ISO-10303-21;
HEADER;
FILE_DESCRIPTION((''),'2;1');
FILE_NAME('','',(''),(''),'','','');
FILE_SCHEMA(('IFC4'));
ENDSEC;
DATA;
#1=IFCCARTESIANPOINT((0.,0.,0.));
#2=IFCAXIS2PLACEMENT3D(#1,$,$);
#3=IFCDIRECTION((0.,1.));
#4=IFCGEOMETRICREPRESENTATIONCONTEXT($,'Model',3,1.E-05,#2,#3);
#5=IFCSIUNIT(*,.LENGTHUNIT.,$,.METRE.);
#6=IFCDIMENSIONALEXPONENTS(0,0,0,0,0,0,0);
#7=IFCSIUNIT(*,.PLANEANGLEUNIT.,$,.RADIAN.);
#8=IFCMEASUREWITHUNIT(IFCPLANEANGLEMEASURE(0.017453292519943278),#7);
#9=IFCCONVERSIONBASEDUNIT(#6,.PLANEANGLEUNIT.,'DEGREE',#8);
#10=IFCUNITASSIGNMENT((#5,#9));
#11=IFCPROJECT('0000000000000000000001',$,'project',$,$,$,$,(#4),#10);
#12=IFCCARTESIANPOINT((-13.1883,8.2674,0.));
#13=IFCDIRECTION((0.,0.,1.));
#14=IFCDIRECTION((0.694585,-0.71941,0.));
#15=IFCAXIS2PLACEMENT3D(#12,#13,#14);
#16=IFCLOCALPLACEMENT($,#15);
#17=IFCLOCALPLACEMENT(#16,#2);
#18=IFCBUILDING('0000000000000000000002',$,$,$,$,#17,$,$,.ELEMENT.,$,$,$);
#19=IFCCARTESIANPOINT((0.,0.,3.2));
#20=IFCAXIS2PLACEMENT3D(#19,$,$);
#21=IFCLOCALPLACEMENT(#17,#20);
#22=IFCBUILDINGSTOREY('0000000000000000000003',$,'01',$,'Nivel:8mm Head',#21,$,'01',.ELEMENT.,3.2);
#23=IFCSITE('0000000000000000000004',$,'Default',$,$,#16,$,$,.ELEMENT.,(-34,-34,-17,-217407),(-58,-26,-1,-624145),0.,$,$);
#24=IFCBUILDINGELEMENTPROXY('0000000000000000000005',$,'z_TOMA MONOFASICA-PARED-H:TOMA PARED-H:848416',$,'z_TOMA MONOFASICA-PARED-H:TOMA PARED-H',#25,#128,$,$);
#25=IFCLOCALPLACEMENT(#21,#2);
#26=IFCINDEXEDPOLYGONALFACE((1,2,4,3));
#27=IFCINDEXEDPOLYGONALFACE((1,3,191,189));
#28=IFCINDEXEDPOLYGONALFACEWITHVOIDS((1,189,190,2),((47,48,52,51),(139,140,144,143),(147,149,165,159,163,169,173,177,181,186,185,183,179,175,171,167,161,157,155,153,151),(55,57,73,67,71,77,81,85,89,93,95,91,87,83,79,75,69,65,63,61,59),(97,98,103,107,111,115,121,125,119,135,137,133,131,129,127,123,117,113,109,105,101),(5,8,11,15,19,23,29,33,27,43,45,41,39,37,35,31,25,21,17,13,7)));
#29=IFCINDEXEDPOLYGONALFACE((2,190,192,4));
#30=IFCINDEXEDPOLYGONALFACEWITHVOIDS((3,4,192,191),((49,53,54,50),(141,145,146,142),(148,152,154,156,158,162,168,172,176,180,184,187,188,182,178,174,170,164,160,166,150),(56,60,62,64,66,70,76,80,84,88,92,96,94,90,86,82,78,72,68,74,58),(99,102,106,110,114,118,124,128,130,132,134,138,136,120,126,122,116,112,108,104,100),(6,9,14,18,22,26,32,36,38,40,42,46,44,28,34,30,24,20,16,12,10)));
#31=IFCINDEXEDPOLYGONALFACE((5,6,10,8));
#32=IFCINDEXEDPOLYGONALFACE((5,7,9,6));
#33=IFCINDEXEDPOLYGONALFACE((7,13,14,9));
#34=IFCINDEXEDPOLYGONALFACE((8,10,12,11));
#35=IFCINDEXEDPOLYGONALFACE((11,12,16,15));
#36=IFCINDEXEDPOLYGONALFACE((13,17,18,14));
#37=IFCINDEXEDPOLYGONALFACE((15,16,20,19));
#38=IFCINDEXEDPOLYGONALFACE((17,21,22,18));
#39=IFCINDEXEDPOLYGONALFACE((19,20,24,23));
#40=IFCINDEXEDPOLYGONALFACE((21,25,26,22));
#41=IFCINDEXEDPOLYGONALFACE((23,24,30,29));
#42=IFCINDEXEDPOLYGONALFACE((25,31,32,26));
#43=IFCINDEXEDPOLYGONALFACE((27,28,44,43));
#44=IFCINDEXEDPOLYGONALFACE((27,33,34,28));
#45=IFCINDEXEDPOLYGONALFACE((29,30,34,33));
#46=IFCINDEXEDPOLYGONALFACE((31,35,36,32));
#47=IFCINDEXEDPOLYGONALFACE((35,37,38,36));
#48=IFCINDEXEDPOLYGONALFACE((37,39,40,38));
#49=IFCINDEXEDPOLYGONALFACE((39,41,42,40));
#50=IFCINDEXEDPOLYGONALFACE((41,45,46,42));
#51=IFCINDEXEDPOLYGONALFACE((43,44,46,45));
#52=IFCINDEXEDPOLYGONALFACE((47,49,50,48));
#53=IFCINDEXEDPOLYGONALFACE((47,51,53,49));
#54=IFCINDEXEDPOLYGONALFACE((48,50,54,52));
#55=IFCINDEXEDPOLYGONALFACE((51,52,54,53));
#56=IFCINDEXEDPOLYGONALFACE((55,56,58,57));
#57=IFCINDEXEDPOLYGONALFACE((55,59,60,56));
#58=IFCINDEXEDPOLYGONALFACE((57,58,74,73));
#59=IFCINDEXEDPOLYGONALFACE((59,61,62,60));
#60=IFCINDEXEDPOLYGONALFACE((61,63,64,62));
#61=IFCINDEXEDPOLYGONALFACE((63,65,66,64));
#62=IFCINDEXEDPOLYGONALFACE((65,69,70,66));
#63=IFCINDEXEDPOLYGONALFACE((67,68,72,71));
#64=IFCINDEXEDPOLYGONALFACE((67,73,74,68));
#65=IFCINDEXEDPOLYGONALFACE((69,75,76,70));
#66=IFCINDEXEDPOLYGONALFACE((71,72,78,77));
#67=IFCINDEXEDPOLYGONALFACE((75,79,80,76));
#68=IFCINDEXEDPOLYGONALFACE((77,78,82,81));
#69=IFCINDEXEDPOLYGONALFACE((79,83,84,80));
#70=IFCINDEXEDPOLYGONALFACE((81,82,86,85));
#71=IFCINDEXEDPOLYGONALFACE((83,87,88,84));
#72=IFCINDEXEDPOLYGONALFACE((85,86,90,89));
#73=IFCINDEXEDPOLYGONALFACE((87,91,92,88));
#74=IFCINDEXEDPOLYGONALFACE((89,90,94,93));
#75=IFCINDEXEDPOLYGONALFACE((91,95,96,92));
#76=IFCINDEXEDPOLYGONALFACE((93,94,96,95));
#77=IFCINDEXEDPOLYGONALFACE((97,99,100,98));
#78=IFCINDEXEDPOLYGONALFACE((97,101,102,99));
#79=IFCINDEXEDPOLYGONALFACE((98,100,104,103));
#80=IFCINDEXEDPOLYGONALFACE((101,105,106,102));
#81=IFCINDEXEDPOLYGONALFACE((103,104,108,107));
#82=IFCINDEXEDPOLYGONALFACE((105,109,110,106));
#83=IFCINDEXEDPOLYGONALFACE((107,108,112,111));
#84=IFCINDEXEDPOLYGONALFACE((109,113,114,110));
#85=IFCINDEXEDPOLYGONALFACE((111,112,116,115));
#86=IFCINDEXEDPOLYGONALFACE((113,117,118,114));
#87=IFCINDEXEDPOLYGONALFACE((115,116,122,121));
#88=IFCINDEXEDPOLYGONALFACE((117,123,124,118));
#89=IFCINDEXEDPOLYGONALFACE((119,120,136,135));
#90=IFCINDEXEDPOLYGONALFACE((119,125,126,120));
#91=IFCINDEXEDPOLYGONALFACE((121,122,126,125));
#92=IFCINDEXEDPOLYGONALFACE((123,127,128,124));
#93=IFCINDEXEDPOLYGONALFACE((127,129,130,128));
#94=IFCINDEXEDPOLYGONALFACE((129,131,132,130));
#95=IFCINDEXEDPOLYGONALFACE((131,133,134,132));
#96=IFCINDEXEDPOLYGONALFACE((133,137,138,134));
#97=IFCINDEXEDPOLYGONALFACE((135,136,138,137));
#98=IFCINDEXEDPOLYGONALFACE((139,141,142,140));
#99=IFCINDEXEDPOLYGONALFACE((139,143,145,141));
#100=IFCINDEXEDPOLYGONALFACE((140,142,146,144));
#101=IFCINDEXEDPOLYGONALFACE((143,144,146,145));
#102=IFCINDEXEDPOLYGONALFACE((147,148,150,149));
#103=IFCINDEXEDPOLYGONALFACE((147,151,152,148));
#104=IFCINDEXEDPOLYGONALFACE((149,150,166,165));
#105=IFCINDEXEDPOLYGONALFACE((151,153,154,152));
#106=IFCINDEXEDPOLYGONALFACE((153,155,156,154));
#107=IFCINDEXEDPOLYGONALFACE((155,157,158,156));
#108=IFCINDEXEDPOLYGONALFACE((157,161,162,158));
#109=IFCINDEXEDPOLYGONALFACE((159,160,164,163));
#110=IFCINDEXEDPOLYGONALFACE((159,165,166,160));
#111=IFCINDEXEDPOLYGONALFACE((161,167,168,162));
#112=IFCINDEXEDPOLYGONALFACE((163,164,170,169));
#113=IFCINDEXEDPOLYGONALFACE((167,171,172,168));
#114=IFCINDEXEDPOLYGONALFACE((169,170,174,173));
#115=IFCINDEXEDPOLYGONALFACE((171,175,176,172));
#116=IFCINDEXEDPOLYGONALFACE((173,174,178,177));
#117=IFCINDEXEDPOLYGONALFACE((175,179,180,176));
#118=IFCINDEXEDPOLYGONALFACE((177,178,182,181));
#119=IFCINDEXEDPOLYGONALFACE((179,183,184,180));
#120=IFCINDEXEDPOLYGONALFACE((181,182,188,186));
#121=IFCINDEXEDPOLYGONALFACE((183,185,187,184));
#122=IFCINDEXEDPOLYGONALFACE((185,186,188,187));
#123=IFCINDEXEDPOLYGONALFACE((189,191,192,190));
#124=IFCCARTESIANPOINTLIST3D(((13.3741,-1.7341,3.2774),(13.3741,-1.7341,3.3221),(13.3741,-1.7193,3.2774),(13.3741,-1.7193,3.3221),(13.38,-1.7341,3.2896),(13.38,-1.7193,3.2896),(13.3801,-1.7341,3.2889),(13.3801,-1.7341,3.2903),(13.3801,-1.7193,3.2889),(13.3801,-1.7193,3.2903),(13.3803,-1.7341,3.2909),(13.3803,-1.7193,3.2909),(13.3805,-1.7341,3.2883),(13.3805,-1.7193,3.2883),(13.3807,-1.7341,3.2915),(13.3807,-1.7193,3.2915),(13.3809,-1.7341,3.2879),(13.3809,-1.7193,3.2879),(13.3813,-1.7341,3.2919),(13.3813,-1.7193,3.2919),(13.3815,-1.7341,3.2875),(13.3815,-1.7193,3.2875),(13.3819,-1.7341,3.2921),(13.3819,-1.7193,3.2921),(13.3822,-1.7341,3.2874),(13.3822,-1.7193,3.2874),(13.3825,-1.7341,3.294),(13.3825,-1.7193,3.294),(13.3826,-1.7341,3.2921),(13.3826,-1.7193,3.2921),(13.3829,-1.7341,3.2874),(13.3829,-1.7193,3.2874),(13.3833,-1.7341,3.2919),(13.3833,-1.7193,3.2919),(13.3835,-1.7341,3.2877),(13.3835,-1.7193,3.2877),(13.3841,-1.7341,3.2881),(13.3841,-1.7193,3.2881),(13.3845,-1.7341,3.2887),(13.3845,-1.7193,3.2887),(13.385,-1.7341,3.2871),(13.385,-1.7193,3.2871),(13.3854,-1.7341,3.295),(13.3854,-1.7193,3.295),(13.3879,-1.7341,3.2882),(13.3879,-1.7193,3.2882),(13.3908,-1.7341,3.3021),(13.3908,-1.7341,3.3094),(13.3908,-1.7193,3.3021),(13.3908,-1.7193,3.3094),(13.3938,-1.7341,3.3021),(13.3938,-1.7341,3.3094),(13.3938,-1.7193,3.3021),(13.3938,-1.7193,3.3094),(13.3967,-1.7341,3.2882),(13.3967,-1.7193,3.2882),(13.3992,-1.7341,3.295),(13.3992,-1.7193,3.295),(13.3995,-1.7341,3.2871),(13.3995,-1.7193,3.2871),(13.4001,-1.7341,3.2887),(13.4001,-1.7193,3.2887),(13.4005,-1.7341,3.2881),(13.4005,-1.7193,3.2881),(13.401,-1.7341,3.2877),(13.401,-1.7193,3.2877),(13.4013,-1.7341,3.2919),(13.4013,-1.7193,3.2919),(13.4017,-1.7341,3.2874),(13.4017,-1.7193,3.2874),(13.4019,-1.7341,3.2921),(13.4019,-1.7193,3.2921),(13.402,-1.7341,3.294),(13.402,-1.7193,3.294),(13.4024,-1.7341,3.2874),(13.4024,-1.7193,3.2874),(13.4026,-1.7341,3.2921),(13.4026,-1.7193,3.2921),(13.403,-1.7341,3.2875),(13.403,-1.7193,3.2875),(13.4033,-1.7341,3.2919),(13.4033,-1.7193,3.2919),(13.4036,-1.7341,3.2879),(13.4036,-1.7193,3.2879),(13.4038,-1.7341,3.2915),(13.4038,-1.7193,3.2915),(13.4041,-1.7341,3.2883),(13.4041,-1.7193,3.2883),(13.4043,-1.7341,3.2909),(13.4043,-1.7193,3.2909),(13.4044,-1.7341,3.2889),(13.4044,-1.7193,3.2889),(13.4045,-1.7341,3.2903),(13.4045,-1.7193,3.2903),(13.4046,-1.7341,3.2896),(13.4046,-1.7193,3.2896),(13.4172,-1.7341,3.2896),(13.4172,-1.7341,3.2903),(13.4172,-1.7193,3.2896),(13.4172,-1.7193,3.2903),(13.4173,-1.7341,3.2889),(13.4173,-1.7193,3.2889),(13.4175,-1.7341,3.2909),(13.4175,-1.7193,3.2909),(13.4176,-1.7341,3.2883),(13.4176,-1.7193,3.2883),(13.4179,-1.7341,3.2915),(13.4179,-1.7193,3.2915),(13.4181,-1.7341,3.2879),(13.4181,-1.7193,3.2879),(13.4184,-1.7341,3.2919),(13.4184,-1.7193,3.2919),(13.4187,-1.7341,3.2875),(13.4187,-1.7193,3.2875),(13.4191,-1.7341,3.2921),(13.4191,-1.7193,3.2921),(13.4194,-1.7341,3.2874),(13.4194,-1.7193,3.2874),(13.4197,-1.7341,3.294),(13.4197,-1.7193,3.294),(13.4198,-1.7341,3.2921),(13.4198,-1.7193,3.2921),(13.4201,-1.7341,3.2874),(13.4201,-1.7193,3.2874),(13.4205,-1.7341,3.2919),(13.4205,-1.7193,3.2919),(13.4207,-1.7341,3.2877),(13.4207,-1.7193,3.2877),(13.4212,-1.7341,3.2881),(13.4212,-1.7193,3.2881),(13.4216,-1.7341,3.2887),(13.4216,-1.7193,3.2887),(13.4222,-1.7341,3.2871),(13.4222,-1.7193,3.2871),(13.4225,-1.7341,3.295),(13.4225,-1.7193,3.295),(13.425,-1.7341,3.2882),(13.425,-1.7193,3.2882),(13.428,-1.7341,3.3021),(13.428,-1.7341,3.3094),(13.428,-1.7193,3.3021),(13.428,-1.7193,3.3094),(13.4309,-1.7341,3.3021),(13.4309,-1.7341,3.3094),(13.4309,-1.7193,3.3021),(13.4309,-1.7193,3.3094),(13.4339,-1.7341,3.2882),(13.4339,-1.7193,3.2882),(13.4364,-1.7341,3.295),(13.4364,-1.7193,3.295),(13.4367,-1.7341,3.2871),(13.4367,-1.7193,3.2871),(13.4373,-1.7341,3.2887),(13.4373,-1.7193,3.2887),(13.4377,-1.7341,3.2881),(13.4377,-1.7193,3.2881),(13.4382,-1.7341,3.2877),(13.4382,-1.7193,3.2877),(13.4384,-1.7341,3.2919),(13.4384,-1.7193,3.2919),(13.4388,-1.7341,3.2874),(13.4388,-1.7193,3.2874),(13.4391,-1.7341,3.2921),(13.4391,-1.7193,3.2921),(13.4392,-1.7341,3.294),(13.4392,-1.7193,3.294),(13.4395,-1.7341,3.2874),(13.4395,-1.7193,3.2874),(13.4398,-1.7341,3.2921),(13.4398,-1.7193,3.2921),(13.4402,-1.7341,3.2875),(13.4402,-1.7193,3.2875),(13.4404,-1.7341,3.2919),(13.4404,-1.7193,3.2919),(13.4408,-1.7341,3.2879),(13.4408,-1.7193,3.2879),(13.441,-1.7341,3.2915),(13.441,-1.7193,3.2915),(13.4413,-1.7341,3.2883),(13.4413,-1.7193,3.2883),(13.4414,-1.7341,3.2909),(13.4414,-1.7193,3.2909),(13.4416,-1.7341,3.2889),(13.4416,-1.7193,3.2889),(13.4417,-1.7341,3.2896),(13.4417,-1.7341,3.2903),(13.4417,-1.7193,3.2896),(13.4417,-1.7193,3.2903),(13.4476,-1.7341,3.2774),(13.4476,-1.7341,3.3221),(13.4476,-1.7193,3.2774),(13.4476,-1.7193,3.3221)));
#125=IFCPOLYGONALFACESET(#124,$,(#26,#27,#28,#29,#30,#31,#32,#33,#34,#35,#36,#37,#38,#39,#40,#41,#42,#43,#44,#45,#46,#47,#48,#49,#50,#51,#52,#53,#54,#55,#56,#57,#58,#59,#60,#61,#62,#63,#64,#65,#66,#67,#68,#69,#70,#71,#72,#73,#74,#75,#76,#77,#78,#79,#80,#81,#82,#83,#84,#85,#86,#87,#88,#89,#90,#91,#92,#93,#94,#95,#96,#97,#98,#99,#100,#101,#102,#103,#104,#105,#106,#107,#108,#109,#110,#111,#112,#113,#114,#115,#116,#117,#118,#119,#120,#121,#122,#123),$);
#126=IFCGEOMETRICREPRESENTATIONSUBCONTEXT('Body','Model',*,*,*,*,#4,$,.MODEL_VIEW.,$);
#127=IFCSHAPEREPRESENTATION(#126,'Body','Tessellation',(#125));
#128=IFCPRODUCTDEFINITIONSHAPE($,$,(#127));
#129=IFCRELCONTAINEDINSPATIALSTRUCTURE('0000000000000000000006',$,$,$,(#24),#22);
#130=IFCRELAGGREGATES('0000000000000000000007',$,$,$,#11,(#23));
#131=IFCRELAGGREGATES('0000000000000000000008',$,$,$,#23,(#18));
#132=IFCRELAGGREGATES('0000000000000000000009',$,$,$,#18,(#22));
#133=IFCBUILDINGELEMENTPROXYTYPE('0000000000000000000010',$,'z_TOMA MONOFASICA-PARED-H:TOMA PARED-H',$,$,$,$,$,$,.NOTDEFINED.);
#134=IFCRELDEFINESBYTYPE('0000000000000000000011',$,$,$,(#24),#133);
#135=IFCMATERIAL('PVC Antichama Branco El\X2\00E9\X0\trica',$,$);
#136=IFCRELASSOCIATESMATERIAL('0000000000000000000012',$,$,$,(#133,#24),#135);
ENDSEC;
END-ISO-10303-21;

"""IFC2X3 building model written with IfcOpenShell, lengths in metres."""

from ifc_helpers import new_model, entity, si_unit, converted_unit, direction, frame, frame_2d, origin, place, context, subcontext, project, spatial, polyline, circle_curve, parameter, trimmed, segment, composite_curve, outline, extrude, source, transform, mapped, material, type_object, type_shapes, element, save


model = new_model("IFC2X3")

# Units and contexts
model_context = context("Model", 3, precision=1e-05, world=origin(), true_north=direction((0.0, 1.0)))
body_context = subcontext(model_context, "Body", "Model", "MODEL_VIEW")
ifc_project = project(units=[si_unit("LENGTHUNIT", "METRE"), converted_unit("PLANEANGLEUNIT", "DEGREE", entity("IfcPlaneAngleMeasure", 0.017453292519943278), si_unit("PLANEANGLEUNIT", "RADIAN"), dimensions=[0, 0, 0, 0, 0, 0, 0])], contexts=[model_context])

# Site, building, storey
site_placement = place(None, frame((-13.1883, 8.2674, 0.0), z_axis=(0.0, 0.0, 1.0), x_axis=(0.694585, -0.71941, 0.0)))
site = spatial("IfcSite", under=ifc_project, at=site_placement, Name="Default", CompositionType="ELEMENT", RefLatitude=(-34, -34, -17, -217407), RefLongitude=(-58, -26, -1, -624145), RefElevation=0.0)
building_placement = place(site_placement, origin())
building = spatial("IfcBuilding", under=site, at=building_placement, CompositionType="ELEMENT")
storey_placement = place(building_placement, frame((0.0, 0.0, 3.2)))
storey = spatial("IfcBuildingStorey", under=building, at=storey_placement, Name="01", ObjectType="Nivel:8mm Head", LongName="01", CompositionType="ELEMENT", Elevation=3.2)

# Building element proxy
ifc_material_1 = material(Name="PVC Antichama Branco Elétrica")
building_element_proxy_type_1 = type_object("IfcBuildingElementProxyType", Name="z_TOMA MONOFASICA-PARED-H:TOMA PARED-H", PredefinedType="NOTDEFINED", material=ifc_material_1)
shared_shape_1 = source(origin(), body_context, "Body", "SweptSolid", [
    extrude(outline(polyline([(-0.0368, -0.0223), (0.0368, -0.0223), (0.0368, 0.0223), (-0.0368, 0.0223), (-0.0368, -0.0223)]), holes=[composite_curve([segment(polyline([(0.0141, 0.0115), (0.0116, 0.0047)]), True, "CONTINUOUS"), segment(polyline([(0.0116, 0.0047), (0.0088, 0.0057)]), True, "CONTINUOUS"), segment(polyline([(0.0088, 0.0057), (0.0096, 0.0078)]), True, "CONTINUOUS"), segment(trimmed(circle_curve(frame_2d((0.0087, 0.0099), x_axis=(1.0, 0.0)), 0.0024), [parameter(27.118901)], [parameter(292.881099)], True, "PARAMETER"), False, "CONTINUOUS"), segment(polyline([(0.0108, 0.011), (0.0113, 0.0126)]), True, "CONTINUOUS"), segment(polyline([(0.0113, 0.0126), (0.0141, 0.0115)]), True, "CONTINUOUS")], self_intersect=False), composite_curve([segment(polyline([(0.0255, 0.0047), (0.023, 0.0115)]), True, "CONTINUOUS"), segment(polyline([(0.023, 0.0115), (0.0258, 0.0126)]), True, "CONTINUOUS"), segment(polyline([(0.0258, 0.0126), (0.0264, 0.011)]), True, "CONTINUOUS"), segment(trimmed(circle_curve(frame_2d((0.0285, 0.0099), x_axis=(1.0, 0.0)), 0.0024), [parameter(247.118901)], [parameter(152.881099)], True, "PARAMETER"), False, "CONTINUOUS"), segment(polyline([(0.0276, 0.0078), (0.0283, 0.0057)]), True, "CONTINUOUS"), segment(polyline([(0.0283, 0.0057), (0.0255, 0.0047)]), True, "CONTINUOUS")], self_intersect=False), polyline([(0.0201, -0.0024), (0.0201, -0.0097), (0.0171, -0.0097), (0.0171, -0.0024), (0.0201, -0.0024)]), composite_curve([segment(polyline([(-0.0141, 0.0115), (-0.0113, 0.0126)]), True, "CONTINUOUS"), segment(polyline([(-0.0113, 0.0126), (-0.0108, 0.011)]), True, "CONTINUOUS"), segment(trimmed(circle_curve(frame_2d((-0.0087, 0.0099), x_axis=(1.0, 0.0)), 0.0024), [parameter(247.118901)], [parameter(152.881099)], True, "PARAMETER"), False, "CONTINUOUS"), segment(polyline([(-0.0096, 0.0078), (-0.0088, 0.0057)]), True, "CONTINUOUS"), segment(polyline([(-0.0088, 0.0057), (-0.0116, 0.0047)]), True, "CONTINUOUS"), segment(polyline([(-0.0116, 0.0047), (-0.0141, 0.0115)]), True, "CONTINUOUS")], self_intersect=False), composite_curve([segment(polyline([(-0.0255, 0.0047), (-0.0283, 0.0057)]), True, "CONTINUOUS"), segment(polyline([(-0.0283, 0.0057), (-0.0276, 0.0078)]), True, "CONTINUOUS"), segment(trimmed(circle_curve(frame_2d((-0.0285, 0.0099), x_axis=(1.0, 0.0)), 0.0024), [parameter(27.118901)], [parameter(292.881099)], True, "PARAMETER"), False, "CONTINUOUS"), segment(polyline([(-0.0264, 0.011), (-0.0258, 0.0126)]), True, "CONTINUOUS"), segment(polyline([(-0.0258, 0.0126), (-0.023, 0.0115)]), True, "CONTINUOUS"), segment(polyline([(-0.023, 0.0115), (-0.0255, 0.0047)]), True, "CONTINUOUS")], self_intersect=False), polyline([(-0.0201, -0.0024), (-0.0171, -0.0024), (-0.0171, -0.0097), (-0.0201, -0.0097), (-0.0201, -0.0024)])]), frame((0.0, -0.005, 0.0223), z_axis=(0.0, 1.0, 0.0), x_axis=(1.0, 0.0, 0.0)), (0.0, 0.0, 1.0), 0.0148),
])
type_shapes(building_element_proxy_type_1, [shared_shape_1])
for number, where, z_axis, x_axis, name in (
    (1, (13.4109, -1.7243, 3.2774), (0.0, 0.0, 1.0), (-1.0, 0.0, 0.0), "z_TOMA MONOFASICA-PARED-H:TOMA PARED-H:848416"),
):
    element("IfcBuildingElementProxy", number, at=place(storey_placement, frame(where, z_axis=z_axis, x_axis=x_axis)), inside=storey, type_object=building_element_proxy_type_1, material=ifc_material_1, Name=name, ObjectType="z_TOMA MONOFASICA-PARED-H:TOMA PARED-H", context=body_context, shape_type="MappedRepresentation", body=[
        mapped(shared_shape_1, transform((0.0, 0.0, 0.0), scale=1.0)),
    ])

save(model, "model.ifc")
